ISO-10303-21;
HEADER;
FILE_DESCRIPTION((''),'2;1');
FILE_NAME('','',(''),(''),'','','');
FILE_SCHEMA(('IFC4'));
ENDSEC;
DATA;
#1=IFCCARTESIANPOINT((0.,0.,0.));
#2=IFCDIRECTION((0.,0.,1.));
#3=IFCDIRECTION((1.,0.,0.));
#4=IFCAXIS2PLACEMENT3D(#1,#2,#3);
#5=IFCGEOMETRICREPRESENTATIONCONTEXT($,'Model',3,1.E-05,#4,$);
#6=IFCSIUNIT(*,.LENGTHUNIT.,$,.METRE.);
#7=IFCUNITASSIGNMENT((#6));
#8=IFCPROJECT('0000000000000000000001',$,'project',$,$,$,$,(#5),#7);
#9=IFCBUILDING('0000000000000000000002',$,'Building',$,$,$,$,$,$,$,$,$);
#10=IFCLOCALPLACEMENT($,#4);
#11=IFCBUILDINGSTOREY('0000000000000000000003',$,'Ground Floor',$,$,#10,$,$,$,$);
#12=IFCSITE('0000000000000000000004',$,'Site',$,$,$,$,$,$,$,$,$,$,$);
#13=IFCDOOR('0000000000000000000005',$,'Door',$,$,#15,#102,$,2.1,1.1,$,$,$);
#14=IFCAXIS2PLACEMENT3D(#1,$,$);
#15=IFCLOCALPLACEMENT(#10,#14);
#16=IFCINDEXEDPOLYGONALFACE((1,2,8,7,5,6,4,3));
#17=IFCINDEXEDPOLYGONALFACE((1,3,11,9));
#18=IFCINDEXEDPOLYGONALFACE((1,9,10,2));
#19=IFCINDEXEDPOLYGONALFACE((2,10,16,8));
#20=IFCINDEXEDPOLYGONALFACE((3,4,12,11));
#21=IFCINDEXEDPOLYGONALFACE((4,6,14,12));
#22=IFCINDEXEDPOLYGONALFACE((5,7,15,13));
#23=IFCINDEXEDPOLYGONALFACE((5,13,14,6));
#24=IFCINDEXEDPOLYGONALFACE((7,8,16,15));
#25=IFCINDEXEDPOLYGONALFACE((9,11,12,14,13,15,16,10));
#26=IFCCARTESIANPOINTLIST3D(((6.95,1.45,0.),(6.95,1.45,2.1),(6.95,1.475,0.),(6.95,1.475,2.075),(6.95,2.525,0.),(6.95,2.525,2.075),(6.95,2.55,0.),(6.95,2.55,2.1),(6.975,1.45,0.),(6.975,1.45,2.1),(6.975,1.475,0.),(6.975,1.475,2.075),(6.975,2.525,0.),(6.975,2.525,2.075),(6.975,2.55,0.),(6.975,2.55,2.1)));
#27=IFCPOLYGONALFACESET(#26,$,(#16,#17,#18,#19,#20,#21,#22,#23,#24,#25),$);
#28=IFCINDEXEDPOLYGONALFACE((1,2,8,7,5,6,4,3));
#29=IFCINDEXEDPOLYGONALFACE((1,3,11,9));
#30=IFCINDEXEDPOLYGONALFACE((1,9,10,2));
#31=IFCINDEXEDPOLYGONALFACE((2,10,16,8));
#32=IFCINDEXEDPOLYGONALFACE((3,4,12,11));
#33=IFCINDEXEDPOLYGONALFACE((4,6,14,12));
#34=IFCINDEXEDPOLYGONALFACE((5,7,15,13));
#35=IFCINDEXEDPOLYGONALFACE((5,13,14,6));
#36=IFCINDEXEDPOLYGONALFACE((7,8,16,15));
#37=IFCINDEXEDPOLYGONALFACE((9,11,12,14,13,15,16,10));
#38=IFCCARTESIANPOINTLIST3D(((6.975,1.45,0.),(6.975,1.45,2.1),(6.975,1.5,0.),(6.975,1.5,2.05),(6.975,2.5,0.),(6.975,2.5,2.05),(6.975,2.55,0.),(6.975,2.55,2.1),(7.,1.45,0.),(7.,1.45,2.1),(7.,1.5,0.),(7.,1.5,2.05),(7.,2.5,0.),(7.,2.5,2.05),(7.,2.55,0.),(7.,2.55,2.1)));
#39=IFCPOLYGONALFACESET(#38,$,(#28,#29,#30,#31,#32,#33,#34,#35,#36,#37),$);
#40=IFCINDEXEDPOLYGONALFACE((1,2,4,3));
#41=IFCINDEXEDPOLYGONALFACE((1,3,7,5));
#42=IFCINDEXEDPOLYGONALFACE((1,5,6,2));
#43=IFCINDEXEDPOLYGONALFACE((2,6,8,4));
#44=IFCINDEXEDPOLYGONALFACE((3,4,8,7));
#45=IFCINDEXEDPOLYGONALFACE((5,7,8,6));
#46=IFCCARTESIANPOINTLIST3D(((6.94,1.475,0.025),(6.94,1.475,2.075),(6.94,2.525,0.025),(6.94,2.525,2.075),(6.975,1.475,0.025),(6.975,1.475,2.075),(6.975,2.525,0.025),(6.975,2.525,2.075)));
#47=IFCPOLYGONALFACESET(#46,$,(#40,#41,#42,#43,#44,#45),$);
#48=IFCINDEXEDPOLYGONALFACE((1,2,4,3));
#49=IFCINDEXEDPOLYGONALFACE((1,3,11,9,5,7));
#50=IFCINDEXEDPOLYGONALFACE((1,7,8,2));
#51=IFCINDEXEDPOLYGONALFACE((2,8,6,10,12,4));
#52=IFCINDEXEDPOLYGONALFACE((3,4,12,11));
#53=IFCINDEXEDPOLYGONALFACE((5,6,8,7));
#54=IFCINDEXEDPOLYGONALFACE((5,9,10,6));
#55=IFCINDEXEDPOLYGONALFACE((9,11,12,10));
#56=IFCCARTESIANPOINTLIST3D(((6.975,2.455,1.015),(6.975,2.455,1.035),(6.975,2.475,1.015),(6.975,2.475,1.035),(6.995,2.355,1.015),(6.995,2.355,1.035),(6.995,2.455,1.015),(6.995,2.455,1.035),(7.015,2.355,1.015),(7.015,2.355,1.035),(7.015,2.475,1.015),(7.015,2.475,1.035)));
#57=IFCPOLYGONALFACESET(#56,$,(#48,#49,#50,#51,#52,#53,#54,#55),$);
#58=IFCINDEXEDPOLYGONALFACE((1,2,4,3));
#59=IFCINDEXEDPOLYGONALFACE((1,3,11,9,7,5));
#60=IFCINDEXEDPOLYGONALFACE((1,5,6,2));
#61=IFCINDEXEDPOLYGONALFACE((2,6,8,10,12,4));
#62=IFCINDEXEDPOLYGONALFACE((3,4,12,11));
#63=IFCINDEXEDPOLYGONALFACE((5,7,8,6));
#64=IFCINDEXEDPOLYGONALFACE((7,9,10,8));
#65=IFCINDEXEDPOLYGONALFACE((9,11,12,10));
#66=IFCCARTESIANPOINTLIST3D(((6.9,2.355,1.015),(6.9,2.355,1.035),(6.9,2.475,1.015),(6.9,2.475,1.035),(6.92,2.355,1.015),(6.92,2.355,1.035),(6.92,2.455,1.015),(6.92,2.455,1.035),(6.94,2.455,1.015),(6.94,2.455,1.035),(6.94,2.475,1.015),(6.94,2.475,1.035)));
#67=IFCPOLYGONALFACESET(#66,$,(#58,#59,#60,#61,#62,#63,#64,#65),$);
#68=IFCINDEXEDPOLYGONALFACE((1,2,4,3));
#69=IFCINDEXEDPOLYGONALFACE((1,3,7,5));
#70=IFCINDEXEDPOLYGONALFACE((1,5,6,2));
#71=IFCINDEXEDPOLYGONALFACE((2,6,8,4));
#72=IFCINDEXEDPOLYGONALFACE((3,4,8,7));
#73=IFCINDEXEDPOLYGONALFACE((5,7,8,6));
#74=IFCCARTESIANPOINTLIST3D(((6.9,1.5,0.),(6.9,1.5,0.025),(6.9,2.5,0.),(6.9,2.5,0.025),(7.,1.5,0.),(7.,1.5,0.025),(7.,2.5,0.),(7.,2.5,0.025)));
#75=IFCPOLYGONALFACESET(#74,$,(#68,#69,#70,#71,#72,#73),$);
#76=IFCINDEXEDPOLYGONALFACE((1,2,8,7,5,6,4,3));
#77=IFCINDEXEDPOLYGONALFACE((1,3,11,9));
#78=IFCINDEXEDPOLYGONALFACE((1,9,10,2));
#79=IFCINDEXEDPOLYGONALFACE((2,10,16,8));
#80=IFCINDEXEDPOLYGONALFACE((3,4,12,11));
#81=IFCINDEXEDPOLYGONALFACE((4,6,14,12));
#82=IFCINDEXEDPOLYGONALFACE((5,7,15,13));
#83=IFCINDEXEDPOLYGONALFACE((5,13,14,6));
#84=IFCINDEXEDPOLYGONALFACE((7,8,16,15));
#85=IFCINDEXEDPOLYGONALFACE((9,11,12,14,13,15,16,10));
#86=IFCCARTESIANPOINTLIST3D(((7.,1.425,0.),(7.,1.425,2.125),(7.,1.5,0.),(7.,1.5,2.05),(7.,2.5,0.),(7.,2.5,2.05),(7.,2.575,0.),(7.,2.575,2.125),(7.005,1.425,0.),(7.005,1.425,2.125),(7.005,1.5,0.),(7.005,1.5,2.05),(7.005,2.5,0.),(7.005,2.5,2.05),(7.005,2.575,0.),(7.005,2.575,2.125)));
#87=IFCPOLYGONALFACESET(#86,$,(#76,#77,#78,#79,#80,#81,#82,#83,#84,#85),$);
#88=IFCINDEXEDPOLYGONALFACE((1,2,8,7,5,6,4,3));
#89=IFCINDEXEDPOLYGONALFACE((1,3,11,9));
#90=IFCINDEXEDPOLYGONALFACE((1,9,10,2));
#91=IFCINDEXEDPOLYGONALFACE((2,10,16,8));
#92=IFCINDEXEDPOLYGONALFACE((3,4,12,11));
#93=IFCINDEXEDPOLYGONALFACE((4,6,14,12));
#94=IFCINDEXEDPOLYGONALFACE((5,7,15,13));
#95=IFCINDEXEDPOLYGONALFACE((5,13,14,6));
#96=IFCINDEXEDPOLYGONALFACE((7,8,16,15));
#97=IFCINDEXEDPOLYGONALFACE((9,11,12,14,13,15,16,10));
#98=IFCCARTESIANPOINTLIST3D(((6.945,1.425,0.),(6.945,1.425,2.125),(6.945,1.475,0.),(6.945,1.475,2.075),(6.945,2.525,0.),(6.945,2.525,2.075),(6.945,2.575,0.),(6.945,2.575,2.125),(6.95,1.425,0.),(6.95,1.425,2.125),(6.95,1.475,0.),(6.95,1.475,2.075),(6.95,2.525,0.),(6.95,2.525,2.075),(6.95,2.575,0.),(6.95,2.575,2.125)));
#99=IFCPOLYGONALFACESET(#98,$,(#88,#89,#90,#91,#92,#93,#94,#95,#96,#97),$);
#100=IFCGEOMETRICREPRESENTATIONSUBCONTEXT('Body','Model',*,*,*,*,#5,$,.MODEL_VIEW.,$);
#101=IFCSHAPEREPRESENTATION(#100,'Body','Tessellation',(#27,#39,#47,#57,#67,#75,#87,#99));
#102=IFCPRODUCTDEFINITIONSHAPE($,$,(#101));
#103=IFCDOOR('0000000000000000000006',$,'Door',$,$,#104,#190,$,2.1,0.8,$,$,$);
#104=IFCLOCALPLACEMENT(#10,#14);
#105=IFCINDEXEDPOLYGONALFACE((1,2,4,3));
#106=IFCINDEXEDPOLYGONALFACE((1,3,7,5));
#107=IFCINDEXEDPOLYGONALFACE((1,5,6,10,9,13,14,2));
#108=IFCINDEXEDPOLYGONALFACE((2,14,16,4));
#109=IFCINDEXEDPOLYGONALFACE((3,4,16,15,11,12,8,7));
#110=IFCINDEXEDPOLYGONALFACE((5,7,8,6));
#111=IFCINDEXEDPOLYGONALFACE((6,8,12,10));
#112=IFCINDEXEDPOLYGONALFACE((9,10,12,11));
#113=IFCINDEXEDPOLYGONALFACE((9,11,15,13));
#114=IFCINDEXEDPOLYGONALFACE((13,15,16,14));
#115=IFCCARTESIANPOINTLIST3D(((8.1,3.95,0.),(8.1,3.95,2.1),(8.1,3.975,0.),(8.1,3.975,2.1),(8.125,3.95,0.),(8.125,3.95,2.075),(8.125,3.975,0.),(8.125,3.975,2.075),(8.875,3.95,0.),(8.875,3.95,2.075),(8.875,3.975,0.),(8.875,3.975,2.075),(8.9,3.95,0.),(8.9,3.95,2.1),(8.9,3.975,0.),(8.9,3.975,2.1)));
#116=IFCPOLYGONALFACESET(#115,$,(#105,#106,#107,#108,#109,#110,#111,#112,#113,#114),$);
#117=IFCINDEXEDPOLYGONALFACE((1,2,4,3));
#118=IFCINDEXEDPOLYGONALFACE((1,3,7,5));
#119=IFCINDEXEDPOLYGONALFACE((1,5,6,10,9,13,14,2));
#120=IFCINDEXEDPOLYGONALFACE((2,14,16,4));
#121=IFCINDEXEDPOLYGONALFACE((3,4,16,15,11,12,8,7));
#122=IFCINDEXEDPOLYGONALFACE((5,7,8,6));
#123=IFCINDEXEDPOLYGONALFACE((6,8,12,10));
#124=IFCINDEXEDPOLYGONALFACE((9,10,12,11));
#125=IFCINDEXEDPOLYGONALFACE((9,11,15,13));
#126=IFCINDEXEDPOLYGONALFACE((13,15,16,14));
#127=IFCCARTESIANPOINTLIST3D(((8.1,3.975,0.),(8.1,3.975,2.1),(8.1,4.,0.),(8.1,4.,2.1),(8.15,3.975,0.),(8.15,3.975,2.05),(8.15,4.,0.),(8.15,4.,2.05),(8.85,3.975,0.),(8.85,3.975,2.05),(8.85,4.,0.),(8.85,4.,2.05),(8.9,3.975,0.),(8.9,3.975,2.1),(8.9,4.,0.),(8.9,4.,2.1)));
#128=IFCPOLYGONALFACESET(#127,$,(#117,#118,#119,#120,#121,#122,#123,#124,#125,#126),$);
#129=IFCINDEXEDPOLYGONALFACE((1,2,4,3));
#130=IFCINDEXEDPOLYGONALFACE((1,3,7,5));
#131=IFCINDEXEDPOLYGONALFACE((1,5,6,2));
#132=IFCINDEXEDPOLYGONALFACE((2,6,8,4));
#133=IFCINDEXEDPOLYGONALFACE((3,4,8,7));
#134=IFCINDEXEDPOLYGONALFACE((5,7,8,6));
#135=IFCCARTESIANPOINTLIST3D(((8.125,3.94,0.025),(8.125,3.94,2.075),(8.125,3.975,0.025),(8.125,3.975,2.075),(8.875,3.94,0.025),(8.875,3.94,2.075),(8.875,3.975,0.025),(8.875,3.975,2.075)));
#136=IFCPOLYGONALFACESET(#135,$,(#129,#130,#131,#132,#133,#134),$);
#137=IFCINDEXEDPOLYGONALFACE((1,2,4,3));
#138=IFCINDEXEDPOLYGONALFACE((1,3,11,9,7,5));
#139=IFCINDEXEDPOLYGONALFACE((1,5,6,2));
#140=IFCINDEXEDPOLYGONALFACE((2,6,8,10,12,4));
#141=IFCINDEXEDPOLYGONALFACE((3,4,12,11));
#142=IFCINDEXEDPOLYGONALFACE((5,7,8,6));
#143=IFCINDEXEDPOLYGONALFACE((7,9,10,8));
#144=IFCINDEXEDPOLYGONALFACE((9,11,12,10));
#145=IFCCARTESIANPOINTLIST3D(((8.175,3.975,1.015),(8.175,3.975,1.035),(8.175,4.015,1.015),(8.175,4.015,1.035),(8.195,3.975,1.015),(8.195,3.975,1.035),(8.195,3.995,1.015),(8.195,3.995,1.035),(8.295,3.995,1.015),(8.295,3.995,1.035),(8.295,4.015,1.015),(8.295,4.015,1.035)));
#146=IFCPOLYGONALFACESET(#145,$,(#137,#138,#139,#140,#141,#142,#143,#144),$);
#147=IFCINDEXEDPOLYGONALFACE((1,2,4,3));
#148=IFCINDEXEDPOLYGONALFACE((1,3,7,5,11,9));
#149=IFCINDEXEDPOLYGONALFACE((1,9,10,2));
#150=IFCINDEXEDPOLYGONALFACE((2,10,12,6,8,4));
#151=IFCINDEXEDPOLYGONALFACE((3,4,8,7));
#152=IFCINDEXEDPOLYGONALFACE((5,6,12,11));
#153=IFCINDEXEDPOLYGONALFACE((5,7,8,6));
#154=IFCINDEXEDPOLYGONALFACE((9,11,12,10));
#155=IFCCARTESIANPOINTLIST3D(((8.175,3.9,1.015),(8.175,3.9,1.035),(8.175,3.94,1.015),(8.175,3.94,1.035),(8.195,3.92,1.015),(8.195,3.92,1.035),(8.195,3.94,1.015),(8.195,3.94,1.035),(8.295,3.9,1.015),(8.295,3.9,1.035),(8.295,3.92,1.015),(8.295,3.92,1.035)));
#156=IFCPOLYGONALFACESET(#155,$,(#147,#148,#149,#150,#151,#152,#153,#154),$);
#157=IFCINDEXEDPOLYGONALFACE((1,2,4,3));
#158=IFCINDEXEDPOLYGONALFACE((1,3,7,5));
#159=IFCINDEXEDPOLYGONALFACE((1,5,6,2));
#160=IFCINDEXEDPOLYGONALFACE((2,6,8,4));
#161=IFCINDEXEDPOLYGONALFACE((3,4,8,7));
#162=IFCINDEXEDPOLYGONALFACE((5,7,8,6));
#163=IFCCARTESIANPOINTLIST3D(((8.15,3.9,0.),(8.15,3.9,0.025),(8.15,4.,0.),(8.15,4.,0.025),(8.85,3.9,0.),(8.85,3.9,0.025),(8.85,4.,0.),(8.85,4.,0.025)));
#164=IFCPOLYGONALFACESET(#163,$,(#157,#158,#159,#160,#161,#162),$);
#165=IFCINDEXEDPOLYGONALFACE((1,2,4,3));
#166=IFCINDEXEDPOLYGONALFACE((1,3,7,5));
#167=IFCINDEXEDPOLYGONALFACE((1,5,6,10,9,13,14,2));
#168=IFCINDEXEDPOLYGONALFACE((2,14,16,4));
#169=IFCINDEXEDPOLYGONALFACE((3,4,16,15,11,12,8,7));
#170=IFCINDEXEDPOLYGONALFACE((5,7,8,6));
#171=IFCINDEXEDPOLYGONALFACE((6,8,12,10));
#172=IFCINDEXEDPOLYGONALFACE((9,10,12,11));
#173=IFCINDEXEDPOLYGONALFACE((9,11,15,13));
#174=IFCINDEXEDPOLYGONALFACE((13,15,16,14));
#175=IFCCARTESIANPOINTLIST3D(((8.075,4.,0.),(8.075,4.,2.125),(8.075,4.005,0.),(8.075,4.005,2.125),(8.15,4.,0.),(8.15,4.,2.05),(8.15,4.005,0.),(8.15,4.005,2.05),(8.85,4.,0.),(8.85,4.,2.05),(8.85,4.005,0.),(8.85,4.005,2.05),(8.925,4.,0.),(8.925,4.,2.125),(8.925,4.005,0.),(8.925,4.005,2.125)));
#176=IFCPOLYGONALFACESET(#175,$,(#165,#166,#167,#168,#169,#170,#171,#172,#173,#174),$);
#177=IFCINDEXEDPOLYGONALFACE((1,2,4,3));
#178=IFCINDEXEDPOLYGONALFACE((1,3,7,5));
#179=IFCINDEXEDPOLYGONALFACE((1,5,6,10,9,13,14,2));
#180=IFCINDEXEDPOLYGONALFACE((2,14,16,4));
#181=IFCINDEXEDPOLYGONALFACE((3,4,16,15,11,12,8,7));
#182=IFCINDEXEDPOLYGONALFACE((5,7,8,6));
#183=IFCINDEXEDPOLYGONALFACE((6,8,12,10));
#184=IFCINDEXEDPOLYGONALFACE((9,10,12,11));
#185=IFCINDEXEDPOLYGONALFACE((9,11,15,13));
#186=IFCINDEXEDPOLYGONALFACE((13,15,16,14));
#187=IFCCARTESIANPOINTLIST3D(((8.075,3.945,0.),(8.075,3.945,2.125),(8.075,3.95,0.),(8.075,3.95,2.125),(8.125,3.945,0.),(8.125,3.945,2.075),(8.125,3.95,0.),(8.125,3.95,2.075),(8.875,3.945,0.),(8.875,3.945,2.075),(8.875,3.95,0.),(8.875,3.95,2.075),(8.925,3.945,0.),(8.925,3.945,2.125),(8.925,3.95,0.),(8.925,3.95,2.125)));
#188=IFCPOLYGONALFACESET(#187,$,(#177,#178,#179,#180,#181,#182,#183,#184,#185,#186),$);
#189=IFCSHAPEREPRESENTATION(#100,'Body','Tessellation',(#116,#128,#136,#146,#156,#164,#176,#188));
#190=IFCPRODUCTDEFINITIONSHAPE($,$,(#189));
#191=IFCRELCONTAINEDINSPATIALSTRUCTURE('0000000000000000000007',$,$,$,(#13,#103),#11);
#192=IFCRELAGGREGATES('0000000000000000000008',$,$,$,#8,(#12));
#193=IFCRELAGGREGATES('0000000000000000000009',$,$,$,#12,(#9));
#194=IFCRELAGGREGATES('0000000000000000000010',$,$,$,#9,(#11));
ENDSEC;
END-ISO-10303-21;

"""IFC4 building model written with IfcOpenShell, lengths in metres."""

from ifc_helpers import new_model, si_unit, frame, origin_with_axes, place, context, subcontext, project, spatial, line, indexed_curve, outline, extrude, element, save


model = new_model("IFC4")

# Units and contexts
model_context = context("Model", 3, precision=1e-05, world=origin_with_axes())
body_context = subcontext(model_context, "Body", "Model", "MODEL_VIEW")
ifc_project = project(units=[si_unit("LENGTHUNIT", "METRE")], contexts=[model_context])

# Site, building, storey
site = spatial("IfcSite", under=ifc_project, Name="Site")
building = spatial("IfcBuilding", under=site, Name="Building")
storey_placement = place(None, origin_with_axes())
storey = spatial("IfcBuildingStorey", under=building, at=storey_placement, Name="Ground Floor")

# Doors
door_1_placement = place(storey_placement, frame((7.0, 1.45, 0.0), z_axis=(0.0, 0.0, 1.0), x_axis=(0.0, 1.0, 0.0)))
element("IfcDoor", 1, at=door_1_placement, inside=storey, Name="Door", OverallHeight=2.1, OverallWidth=1.1, context=body_context, shape_type="SweptSolid", body=[
    extrude(outline(indexed_curve([(0.0, 0.0), (0.0, 2.1), (1.1, 2.1), (1.1, 0.0), (1.075, 0.0), (1.075, 2.075), (0.025, 2.075), (0.025, 0.0)], segments=[line(1, 2, 3, 4, 5, 6, 7, 8, 1)])), frame((0.0, 0.025, 0.0), z_axis=(0.0, -1.0, 0.0), x_axis=(1.0, 0.0, 0.0)), (0.0, 0.0, -1.0), 0.025),
    extrude(outline(indexed_curve([(0.0, 0.0), (0.0, 2.1), (1.1, 2.1), (1.1, 0.0), (1.05, 0.0), (1.05, 2.05), (0.05, 2.05), (0.05, 0.0)], segments=[line(1, 2, 3, 4, 5, 6, 7, 8, 1)])), frame((0.0, 0.0, 0.0), z_axis=(0.0, -1.0, 0.0), x_axis=(1.0, 0.0, 0.0)), (0.0, 0.0, -1.0), 0.025),
    extrude(outline(indexed_curve([(0.0, 0.0), (1.05, 0.0), (1.05, 0.035), (0.0, 0.035)], segments=[line(1, 2, 3, 4, 1)])), frame((0.025, 0.025, 0.025), z_axis=(0.0, 0.0, 1.0), x_axis=(1.0, 0.0, 0.0)), (0.0, 0.0, 1.0), 2.05),
    extrude(outline(indexed_curve([(0.0, 0.0), (0.0, -0.04), (-0.12, -0.04), (-0.12, -0.02), (-0.02, -0.02), (-0.02, 0.0)], segments=[line(1, 2, 3, 4, 5, 6, 1)])), frame((1.025, 0.025, 1.015), z_axis=(0.0, 0.0, 1.0), x_axis=(1.0, 0.0, 0.0)), (0.0, 0.0, 1.0), 0.02),
    extrude(outline(indexed_curve([(0.0, 0.0), (0.0, 0.04), (-0.12, 0.04), (-0.12, 0.02), (-0.02, 0.02), (-0.02, 0.0)], segments=[line(1, 2, 3, 4, 5, 6, 1)])), frame((1.025, 0.06, 1.015), z_axis=(0.0, 0.0, 1.0), x_axis=(1.0, 0.0, 0.0)), (0.0, 0.0, 1.0), 0.02),
    extrude(outline(indexed_curve([(0.0, 0.0), (1.0, 0.0), (1.0, 0.1), (0.0, 0.1)], segments=[line(1, 2, 3, 4, 1)])), frame((0.05, 0.0, 0.0), z_axis=(0.0, 0.0, 1.0), x_axis=(1.0, 0.0, 0.0)), (0.0, 0.0, 1.0), 0.025),
    extrude(outline(indexed_curve([(0.0, 0.0), (0.0, 2.125), (1.15, 2.125), (1.15, 0.0), (1.075, 0.0), (1.075, 2.05), (0.075, 2.05), (0.075, 0.0)], segments=[line(1, 2, 3, 4, 5, 6, 7, 8, 1)])), frame((-0.025, -0.005, 0.0), z_axis=(0.0, -1.0, 0.0), x_axis=(1.0, 0.0, 0.0)), (0.0, 0.0, -1.0), 0.005),
    extrude(outline(indexed_curve([(0.0, 0.0), (0.0, 2.125), (1.15, 2.125), (1.15, 0.0), (1.1, 0.0), (1.1, 2.075), (0.05, 2.075), (0.05, 0.0)], segments=[line(1, 2, 3, 4, 5, 6, 7, 8, 1)])), frame((-0.025, 0.05, 0.0), z_axis=(0.0, -1.0, 0.0), x_axis=(1.0, 0.0, 0.0)), (0.0, 0.0, -1.0), 0.005),
])
door_2_placement = place(storey_placement, frame((8.9, 4.0, 0.0), z_axis=(0.0, 0.0, 1.0), x_axis=(-1.0, 0.0, 0.0)))
element("IfcDoor", 2, at=door_2_placement, inside=storey, Name="Door", OverallHeight=2.1, OverallWidth=0.8, context=body_context, shape_type="SweptSolid", body=[
    extrude(outline(indexed_curve([(0.0, 0.0), (0.0, 2.1), (0.8, 2.1), (0.8, 0.0), (0.775, 0.0), (0.775, 2.075), (0.025, 2.075), (0.025, 0.0)], segments=[line(1, 2, 3, 4, 5, 6, 7, 8, 1)])), frame((0.0, 0.025, 0.0), z_axis=(0.0, -1.0, 0.0), x_axis=(1.0, 0.0, 0.0)), (0.0, 0.0, -1.0), 0.025),
    extrude(outline(indexed_curve([(0.0, 0.0), (0.0, 2.1), (0.8, 2.1), (0.8, 0.0), (0.75, 0.0), (0.75, 2.05), (0.05, 2.05), (0.05, 0.0)], segments=[line(1, 2, 3, 4, 5, 6, 7, 8, 1)])), frame((0.0, 0.0, 0.0), z_axis=(0.0, -1.0, 0.0), x_axis=(1.0, 0.0, 0.0)), (0.0, 0.0, -1.0), 0.025),
    extrude(outline(indexed_curve([(0.0, 0.0), (0.75, 0.0), (0.75, 0.035), (0.0, 0.035)], segments=[line(1, 2, 3, 4, 1)])), frame((0.025, 0.025, 0.025), z_axis=(0.0, 0.0, 1.0), x_axis=(1.0, 0.0, 0.0)), (0.0, 0.0, 1.0), 2.05),
    extrude(outline(indexed_curve([(0.0, 0.0), (0.0, -0.04), (-0.12, -0.04), (-0.12, -0.02), (-0.02, -0.02), (-0.02, 0.0)], segments=[line(1, 2, 3, 4, 5, 6, 1)])), frame((0.725, 0.025, 1.015), z_axis=(0.0, 0.0, 1.0), x_axis=(1.0, 0.0, 0.0)), (0.0, 0.0, 1.0), 0.02),
    extrude(outline(indexed_curve([(0.0, 0.0), (0.0, 0.04), (-0.12, 0.04), (-0.12, 0.02), (-0.02, 0.02), (-0.02, 0.0)], segments=[line(1, 2, 3, 4, 5, 6, 1)])), frame((0.725, 0.06, 1.015), z_axis=(0.0, 0.0, 1.0), x_axis=(1.0, 0.0, 0.0)), (0.0, 0.0, 1.0), 0.02),
    extrude(outline(indexed_curve([(0.0, 0.0), (0.7, 0.0), (0.7, 0.1), (0.0, 0.1)], segments=[line(1, 2, 3, 4, 1)])), frame((0.05, 0.0, 0.0), z_axis=(0.0, 0.0, 1.0), x_axis=(1.0, 0.0, 0.0)), (0.0, 0.0, 1.0), 0.025),
    extrude(outline(indexed_curve([(0.0, 0.0), (0.0, 2.125), (0.85, 2.125), (0.85, 0.0), (0.775, 0.0), (0.775, 2.05), (0.075, 2.05), (0.075, 0.0)], segments=[line(1, 2, 3, 4, 5, 6, 7, 8, 1)])), frame((-0.025, -0.005, 0.0), z_axis=(0.0, -1.0, 0.0), x_axis=(1.0, 0.0, 0.0)), (0.0, 0.0, -1.0), 0.005),
    extrude(outline(indexed_curve([(0.0, 0.0), (0.0, 2.125), (0.85, 2.125), (0.85, 0.0), (0.8, 0.0), (0.8, 2.075), (0.05, 2.075), (0.05, 0.0)], segments=[line(1, 2, 3, 4, 5, 6, 7, 8, 1)])), frame((-0.025, 0.05, 0.0), z_axis=(0.0, -1.0, 0.0), x_axis=(1.0, 0.0, 0.0)), (0.0, 0.0, -1.0), 0.005),
])

save(model, "model.ifc")
